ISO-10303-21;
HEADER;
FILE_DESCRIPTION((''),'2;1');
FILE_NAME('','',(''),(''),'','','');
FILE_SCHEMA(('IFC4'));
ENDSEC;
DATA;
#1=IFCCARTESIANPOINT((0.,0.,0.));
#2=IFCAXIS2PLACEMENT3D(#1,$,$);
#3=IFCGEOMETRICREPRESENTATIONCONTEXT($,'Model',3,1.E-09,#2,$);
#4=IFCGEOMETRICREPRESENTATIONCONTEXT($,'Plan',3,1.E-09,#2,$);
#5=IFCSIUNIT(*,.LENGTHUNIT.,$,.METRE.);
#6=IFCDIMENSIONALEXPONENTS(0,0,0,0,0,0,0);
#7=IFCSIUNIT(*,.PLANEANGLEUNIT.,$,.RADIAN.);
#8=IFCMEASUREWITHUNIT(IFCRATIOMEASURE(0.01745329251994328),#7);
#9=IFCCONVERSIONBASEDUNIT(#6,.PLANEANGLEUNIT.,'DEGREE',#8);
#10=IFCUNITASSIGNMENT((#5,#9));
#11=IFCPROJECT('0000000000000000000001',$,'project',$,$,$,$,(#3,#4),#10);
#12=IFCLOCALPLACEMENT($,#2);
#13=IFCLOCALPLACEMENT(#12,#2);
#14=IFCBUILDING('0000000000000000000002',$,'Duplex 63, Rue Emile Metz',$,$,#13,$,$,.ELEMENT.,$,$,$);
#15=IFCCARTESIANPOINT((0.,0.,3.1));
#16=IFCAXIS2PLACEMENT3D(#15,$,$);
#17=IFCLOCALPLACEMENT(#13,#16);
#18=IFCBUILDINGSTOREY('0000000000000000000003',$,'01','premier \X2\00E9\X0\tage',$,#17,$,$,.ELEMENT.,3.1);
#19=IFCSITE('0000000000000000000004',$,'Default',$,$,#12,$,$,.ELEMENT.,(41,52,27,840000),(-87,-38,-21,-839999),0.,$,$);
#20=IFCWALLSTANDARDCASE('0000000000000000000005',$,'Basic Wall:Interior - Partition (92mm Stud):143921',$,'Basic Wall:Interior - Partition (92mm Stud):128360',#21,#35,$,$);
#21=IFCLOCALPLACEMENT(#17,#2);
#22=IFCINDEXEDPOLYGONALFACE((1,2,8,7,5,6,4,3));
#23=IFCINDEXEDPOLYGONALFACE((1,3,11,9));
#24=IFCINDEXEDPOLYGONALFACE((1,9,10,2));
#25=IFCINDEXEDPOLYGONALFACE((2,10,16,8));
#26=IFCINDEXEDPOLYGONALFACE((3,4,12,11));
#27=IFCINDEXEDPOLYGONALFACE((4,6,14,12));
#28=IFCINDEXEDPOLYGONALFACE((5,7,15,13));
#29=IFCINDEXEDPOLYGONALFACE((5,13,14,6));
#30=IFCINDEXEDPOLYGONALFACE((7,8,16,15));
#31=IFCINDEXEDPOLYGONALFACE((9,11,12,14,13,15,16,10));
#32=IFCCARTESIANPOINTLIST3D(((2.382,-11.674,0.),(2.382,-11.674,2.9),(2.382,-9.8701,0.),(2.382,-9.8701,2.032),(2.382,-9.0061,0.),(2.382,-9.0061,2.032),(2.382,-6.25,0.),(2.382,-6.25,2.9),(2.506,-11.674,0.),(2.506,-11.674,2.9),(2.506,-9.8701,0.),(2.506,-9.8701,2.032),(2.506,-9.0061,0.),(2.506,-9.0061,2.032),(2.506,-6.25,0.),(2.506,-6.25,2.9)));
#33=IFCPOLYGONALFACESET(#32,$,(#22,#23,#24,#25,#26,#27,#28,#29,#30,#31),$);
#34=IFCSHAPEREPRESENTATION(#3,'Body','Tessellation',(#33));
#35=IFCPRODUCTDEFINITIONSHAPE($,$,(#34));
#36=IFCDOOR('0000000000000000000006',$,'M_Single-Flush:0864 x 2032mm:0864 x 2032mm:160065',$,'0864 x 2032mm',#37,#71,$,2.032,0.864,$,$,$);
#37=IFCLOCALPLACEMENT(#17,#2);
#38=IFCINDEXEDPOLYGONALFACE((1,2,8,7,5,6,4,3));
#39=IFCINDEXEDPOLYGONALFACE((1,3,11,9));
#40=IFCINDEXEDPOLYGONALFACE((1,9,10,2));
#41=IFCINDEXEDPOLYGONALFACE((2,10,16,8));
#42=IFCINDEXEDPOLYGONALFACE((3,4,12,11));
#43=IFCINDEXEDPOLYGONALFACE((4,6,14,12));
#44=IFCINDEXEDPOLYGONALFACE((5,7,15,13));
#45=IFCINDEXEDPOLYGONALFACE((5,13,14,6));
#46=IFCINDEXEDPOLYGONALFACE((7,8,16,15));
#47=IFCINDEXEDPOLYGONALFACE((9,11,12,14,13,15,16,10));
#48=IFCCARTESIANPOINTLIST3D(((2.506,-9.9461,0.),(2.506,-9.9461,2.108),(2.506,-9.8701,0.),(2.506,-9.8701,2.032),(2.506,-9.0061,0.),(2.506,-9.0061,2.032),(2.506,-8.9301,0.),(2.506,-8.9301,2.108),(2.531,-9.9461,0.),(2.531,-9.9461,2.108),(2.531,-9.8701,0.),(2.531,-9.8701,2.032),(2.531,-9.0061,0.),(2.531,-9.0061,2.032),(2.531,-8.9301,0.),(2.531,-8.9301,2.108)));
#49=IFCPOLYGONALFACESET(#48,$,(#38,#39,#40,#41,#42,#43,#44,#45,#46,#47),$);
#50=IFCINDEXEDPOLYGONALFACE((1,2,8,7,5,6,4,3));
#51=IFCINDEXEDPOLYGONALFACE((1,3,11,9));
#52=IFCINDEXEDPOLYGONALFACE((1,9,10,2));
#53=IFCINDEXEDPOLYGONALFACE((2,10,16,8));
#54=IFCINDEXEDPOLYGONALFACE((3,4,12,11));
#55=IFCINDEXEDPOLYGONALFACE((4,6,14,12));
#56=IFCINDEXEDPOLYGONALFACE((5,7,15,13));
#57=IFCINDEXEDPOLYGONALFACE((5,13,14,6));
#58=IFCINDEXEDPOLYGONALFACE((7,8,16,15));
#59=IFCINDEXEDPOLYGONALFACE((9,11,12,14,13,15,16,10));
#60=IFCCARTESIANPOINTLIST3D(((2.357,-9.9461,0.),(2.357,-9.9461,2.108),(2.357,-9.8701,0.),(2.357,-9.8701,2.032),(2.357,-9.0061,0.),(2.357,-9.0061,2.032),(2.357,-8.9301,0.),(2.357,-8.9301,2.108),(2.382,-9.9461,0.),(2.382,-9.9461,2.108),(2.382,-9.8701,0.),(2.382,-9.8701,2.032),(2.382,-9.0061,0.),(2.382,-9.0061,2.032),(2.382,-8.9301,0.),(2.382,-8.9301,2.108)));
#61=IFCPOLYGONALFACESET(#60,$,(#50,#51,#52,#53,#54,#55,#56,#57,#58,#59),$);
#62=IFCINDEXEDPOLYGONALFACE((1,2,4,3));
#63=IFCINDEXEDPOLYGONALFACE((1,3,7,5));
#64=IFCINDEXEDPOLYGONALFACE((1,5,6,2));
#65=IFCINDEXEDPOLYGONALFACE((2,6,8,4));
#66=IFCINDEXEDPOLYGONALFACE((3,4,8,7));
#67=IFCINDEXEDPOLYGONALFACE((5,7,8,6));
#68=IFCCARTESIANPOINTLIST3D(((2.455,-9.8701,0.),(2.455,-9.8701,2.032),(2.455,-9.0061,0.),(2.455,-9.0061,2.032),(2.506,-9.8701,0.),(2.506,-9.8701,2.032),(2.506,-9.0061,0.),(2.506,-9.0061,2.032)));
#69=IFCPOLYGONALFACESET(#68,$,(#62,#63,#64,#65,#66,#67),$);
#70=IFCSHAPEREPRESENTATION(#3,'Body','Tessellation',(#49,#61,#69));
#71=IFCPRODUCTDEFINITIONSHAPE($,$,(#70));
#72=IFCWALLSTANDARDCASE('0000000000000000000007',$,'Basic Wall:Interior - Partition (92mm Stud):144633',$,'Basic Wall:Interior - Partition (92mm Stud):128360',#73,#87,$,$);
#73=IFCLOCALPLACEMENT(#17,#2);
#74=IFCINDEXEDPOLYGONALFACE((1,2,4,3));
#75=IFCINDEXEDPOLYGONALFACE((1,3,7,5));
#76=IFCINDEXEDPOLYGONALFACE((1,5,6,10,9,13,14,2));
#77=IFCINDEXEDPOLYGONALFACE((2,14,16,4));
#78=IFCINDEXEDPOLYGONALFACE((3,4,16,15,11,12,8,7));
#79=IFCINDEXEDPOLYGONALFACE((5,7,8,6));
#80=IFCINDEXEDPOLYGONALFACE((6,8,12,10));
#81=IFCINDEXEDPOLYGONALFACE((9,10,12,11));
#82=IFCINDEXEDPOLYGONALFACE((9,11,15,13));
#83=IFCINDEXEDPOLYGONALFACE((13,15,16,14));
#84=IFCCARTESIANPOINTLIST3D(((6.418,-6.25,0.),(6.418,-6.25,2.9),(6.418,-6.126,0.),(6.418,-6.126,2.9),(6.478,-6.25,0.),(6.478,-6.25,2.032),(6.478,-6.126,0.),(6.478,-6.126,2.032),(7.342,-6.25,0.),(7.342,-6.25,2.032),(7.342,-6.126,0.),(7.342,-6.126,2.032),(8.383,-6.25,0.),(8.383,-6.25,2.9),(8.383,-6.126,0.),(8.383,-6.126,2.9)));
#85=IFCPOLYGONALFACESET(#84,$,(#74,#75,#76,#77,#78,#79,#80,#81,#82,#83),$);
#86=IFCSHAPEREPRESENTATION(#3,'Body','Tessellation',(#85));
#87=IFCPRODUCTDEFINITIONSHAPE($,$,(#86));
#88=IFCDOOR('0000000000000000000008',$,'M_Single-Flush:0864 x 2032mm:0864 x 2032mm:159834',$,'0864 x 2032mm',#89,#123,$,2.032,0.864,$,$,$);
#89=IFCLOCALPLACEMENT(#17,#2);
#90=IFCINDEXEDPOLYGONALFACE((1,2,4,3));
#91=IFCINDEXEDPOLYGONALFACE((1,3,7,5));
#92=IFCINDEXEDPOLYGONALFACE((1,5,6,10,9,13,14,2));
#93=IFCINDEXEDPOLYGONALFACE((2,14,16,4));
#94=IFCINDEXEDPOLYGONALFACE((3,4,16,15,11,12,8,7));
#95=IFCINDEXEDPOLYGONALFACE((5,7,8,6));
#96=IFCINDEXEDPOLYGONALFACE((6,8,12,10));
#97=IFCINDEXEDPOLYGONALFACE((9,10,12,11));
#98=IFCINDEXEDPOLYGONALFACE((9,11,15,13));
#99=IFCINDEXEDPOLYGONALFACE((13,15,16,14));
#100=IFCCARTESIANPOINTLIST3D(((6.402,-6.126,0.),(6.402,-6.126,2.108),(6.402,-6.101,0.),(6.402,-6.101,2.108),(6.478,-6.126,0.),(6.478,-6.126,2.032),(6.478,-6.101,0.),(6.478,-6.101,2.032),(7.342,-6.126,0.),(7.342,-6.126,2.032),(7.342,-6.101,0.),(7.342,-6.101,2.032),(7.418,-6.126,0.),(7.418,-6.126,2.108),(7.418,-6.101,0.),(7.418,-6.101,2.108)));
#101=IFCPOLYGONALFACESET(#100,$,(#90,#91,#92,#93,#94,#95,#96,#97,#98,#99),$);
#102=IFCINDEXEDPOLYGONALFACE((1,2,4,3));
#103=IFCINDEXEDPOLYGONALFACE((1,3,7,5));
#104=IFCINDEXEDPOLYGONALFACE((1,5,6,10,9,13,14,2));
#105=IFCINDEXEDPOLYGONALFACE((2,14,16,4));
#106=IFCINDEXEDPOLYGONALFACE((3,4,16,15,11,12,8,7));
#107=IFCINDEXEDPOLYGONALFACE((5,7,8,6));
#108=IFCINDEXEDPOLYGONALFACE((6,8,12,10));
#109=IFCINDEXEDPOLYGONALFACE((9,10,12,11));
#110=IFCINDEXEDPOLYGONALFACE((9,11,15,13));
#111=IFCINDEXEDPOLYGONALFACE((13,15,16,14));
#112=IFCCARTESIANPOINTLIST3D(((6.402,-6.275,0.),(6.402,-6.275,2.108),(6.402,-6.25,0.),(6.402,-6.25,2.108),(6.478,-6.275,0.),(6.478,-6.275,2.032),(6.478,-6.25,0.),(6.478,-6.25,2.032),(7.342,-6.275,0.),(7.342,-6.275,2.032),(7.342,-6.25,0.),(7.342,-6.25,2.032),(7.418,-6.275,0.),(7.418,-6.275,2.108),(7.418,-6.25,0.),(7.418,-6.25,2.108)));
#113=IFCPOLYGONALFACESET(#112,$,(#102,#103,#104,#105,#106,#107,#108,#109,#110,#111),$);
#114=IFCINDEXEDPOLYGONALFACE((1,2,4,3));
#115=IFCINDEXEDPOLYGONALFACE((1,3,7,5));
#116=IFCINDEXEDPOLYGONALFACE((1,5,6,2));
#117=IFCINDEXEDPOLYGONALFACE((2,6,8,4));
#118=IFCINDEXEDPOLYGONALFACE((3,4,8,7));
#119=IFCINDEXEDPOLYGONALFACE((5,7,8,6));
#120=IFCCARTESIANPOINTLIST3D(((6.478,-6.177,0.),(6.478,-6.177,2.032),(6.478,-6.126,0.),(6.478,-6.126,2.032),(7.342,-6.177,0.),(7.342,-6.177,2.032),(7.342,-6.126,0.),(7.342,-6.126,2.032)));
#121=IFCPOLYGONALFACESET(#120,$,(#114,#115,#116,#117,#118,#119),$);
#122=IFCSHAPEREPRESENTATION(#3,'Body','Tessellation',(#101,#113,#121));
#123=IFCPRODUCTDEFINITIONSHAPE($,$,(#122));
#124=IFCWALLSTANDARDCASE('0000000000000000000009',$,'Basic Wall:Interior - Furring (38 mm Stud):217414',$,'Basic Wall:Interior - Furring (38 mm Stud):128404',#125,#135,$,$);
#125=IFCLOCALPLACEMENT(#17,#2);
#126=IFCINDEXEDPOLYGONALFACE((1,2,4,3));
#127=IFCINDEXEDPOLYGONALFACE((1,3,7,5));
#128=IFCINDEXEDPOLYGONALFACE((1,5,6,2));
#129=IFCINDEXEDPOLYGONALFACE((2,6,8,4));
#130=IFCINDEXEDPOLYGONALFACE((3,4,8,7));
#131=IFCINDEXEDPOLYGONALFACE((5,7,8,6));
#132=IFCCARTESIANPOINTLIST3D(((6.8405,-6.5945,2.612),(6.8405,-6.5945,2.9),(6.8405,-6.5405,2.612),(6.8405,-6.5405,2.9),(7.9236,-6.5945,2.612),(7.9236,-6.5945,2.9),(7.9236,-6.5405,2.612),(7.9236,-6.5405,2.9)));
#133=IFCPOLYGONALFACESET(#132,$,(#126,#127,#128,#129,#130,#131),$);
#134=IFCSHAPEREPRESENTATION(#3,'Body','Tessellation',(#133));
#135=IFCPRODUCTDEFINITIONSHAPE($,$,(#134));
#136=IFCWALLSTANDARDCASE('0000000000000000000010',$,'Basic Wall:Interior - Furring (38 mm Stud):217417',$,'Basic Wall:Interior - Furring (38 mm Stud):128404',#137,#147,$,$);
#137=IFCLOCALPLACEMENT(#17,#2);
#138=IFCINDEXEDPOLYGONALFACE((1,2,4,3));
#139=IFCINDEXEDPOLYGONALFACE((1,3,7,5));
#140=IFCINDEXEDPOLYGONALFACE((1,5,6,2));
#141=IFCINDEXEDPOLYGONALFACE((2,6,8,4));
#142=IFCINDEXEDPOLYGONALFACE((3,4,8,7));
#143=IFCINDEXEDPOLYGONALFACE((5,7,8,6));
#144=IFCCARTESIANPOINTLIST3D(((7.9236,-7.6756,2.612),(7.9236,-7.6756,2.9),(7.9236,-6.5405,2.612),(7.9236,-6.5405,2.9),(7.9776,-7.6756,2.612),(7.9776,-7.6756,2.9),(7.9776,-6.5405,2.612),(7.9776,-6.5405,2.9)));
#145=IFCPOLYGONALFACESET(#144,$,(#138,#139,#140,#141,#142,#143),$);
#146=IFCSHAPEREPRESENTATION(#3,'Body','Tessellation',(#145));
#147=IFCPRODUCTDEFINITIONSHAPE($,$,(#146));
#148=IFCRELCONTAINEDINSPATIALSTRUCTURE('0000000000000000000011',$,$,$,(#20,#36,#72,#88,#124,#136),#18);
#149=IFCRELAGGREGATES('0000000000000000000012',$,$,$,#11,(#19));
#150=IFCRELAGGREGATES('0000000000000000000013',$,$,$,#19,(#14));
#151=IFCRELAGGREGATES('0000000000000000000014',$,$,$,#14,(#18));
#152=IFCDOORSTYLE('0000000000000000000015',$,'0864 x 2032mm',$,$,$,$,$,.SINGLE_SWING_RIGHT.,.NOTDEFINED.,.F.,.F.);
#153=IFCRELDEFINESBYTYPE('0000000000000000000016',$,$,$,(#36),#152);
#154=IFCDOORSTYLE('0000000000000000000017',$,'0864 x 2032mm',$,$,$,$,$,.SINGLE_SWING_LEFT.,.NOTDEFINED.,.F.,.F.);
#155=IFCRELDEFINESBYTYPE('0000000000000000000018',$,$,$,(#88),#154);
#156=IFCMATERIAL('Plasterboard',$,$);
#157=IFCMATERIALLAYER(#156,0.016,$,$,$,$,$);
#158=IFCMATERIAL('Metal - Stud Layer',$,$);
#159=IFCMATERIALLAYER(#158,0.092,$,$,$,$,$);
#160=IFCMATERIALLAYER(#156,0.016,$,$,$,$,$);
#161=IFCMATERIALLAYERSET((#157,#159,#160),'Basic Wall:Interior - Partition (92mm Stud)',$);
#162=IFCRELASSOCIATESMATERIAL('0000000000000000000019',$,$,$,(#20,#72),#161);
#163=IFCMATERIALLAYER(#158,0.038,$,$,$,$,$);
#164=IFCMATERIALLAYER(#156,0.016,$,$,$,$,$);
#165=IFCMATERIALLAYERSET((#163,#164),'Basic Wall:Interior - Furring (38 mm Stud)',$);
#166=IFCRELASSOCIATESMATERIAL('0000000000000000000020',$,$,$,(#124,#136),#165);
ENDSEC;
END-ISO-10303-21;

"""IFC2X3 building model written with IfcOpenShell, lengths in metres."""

from ifc_helpers import new_model, entity, si_unit, converted_unit, frame, frame_2d, origin, origin_2d_with_axis, place, context, project, spatial, polyline, rectangle, outline, extrude, source, transform, mapped, material, layer, layer_set, layer_usage, type_object, type_shapes, element, fill, save


model = new_model("IFC2X3")

# Units and contexts
model_context = context("Model", 3, precision=1e-09, world=origin())
plan_context = context("Plan", 3, precision=1e-09, world=origin())
ifc_project = project(units=[si_unit("LENGTHUNIT", "METRE"), converted_unit("PLANEANGLEUNIT", "DEGREE", entity("IfcRatioMeasure", 0.01745329251994328), si_unit("PLANEANGLEUNIT", "RADIAN"), dimensions=[0, 0, 0, 0, 0, 0, 0])], contexts=[model_context, plan_context])

# Site, building, storey
site_placement = place(None, origin())
site = spatial("IfcSite", under=ifc_project, at=site_placement, Name="Default", CompositionType="ELEMENT", RefLatitude=(41, 52, 27, 840000), RefLongitude=(-87, -38, -21, -839999), RefElevation=0.0)
building_placement = place(site_placement, origin())
building = spatial("IfcBuilding", under=site, at=building_placement, Name="Duplex 63, Rue Emile Metz", CompositionType="ELEMENT")
storey_placement = place(building_placement, frame((0.0, 0.0, 3.1)))
storey = spatial("IfcBuildingStorey", under=building, at=storey_placement, Name="01", Description="premier étage", CompositionType="ELEMENT", Elevation=3.1)

# Wall, opening, door
ifc_material_1 = material(Name="Plasterboard")
ifc_layer_1 = layer(ifc_material_1, 0.016)
ifc_material_2 = material(Name="Metal - Stud Layer")
ifc_layer_2 = layer(ifc_material_2, 0.092)
ifc_layer_3 = layer(ifc_material_1, 0.016)
ifc_layer_set_1 = layer_set([ifc_layer_1, ifc_layer_2, ifc_layer_3], Name="Basic Wall:Interior - Partition (92mm Stud)")
ifc_layer_usage_1 = layer_usage(ifc_layer_set_1, "AXIS2", "NEGATIVE", 0.062)
wall_1_placement = place(storey_placement, frame((2.444, -6.25, 0.0), z_axis=(0.0, 0.0, 1.0), x_axis=(0.0, -1.0, 0.0)))
wall_1 = element("IfcWallStandardCase", 1, at=wall_1_placement, inside=storey, material=ifc_layer_usage_1, Name="Basic Wall:Interior - Partition (92mm Stud):143921", ObjectType="Basic Wall:Interior - Partition (92mm Stud):128360", context=model_context, shape_type="SweptSolid", body=[
    extrude(rectangle(XDim=5.424, YDim=0.124, at=frame_2d((2.712, 0.0), x_axis=(-1.0, 0.0))), origin(), (0.0, 0.0, 1.0), 2.9),
])
opening_1_placement = place(wall_1_placement, frame((2.7561, -0.062, 0.0)))
opening_1 = element("IfcOpeningElement", 2, at=opening_1_placement, cuts=wall_1, ObjectType="Opening", context=model_context, shape_type="SweptSolid", body=[
    extrude(rectangle(XDim=0.864, YDim=2.032, at=frame_2d((1.016, 0.432), x_axis=(0.0, 1.0))), frame((0.0, 0.0, 0.0), z_axis=(0.0, 1.0, 0.0), x_axis=(0.0, 0.0, 1.0)), (0.0, 0.0, 1.0), 0.124),
])
door_style_1 = type_object("IfcDoorStyle", Name="0864 x 2032mm", ConstructionType="NOTDEFINED", OperationType="SINGLE_SWING_RIGHT", ParameterTakesPrecedence=False, Sizeable=False)
shared_shape_1 = source(origin(), model_context, "Body", "SweptSolid", [
    extrude(outline(polyline([(-0.508, -1.073), (0.508, -1.073), (0.508, 1.035), (0.432, 1.035), (0.432, -0.997), (-0.432, -0.997), (-0.432, 1.035), (-0.508, 1.035), (-0.508, -1.073)])), frame((0.432, 0.124, 1.035), z_axis=(0.0, 1.0, 0.0), x_axis=(1.0, 0.0, 0.0)), (0.0, 0.0, 1.0), 0.025),
    extrude(outline(polyline([(-1.073, -0.508), (1.035, -0.508), (1.035, -0.432), (-0.997, -0.432), (-0.997, 0.432), (1.035, 0.432), (1.035, 0.508), (-1.073, 0.508), (-1.073, -0.508)])), frame((0.432, -0.025, 1.035), z_axis=(0.0, 1.0, 0.0), x_axis=(0.0, 0.0, -1.0)), (0.0, 0.0, 1.0), 0.025),
    extrude(rectangle(XDim=0.051, YDim=0.864, at=origin_2d_with_axis()), frame((0.432, 0.0985, 0.0), z_axis=(0.0, 0.0, 1.0), x_axis=(0.0, 1.0, 0.0)), (0.0, 0.0, 1.0), 2.032),
])
type_shapes(door_style_1, [shared_shape_1])
door_1_placement = place(opening_1_placement, origin())
door_1 = element("IfcDoor", 3, at=door_1_placement, inside=storey, type_object=door_style_1, Name="M_Single-Flush:0864 x 2032mm:0864 x 2032mm:160065", ObjectType="0864 x 2032mm", OverallHeight=2.032, OverallWidth=0.864, context=model_context, shape_type="MappedRepresentation", body=[
    mapped(shared_shape_1, transform((0.0, 0.0, 0.0), scale=1.0)),
])
fill(opening_1, door_1)

# Wall, opening, door
wall_2_placement = place(storey_placement, frame((6.418, -6.188, 0.0)))
wall_2 = element("IfcWallStandardCase", 4, at=wall_2_placement, inside=storey, material=ifc_layer_usage_1, Name="Basic Wall:Interior - Partition (92mm Stud):144633", ObjectType="Basic Wall:Interior - Partition (92mm Stud):128360", context=model_context, shape_type="SweptSolid", body=[
    extrude(rectangle(XDim=1.965, YDim=0.124, at=frame_2d((0.9825, 0.0), x_axis=(-1.0, 0.0))), origin(), (0.0, 0.0, 1.0), 2.9),
])
opening_2_placement = place(wall_2_placement, frame((0.06, -0.062, 0.0)))
opening_2 = element("IfcOpeningElement", 5, at=opening_2_placement, cuts=wall_2, ObjectType="Opening", context=model_context, shape_type="SweptSolid", body=[
    extrude(rectangle(XDim=0.864, YDim=2.032, at=frame_2d((1.016, 0.432), x_axis=(0.0, -1.0))), frame((0.0, 0.0, 0.0), z_axis=(0.0, 1.0, 0.0), x_axis=(0.0, 0.0, 1.0)), (0.0, 0.0, 1.0), 0.124),
])
door_style_2 = type_object("IfcDoorStyle", Name="0864 x 2032mm", ConstructionType="NOTDEFINED", OperationType="SINGLE_SWING_LEFT", ParameterTakesPrecedence=False, Sizeable=False)
shared_shape_2 = source(origin(), model_context, "Body", "SweptSolid", [
    extrude(outline(polyline([(-0.508, -1.073), (0.508, -1.073), (0.508, 1.035), (0.432, 1.035), (0.432, -0.997), (-0.432, -0.997), (-0.432, 1.035), (-0.508, 1.035), (-0.508, -1.073)])), frame((0.432, 0.149, 1.035), z_axis=(0.0, -1.0, 0.0), x_axis=(-1.0, 0.0, 0.0)), (0.0, 0.0, 1.0), 0.025),
    extrude(outline(polyline([(-1.073, -0.508), (1.035, -0.508), (1.035, -0.432), (-0.997, -0.432), (-0.997, 0.432), (1.035, 0.432), (1.035, 0.508), (-1.073, 0.508), (-1.073, -0.508)])), frame((0.432, 0.0, 1.035), z_axis=(0.0, -1.0, 0.0), x_axis=(0.0, 0.0, -1.0)), (0.0, 0.0, 1.0), 0.025),
    extrude(rectangle(XDim=0.864, YDim=0.051, at=origin_2d_with_axis()), frame((0.432, 0.0985, 0.0)), (0.0, 0.0, 1.0), 2.032),
])
type_shapes(door_style_2, [shared_shape_2])
door_2_placement = place(opening_2_placement, origin())
door_2 = element("IfcDoor", 6, at=door_2_placement, inside=storey, type_object=door_style_2, Name="M_Single-Flush:0864 x 2032mm:0864 x 2032mm:159834", ObjectType="0864 x 2032mm", OverallHeight=2.032, OverallWidth=0.864, context=model_context, shape_type="MappedRepresentation", body=[
    mapped(shared_shape_2, transform((0.0, 0.0, 0.0), scale=1.0)),
])
fill(opening_2, door_2)

# Walls
ifc_layer_4 = layer(ifc_material_2, 0.038)
ifc_layer_5 = layer(ifc_material_1, 0.016)
ifc_layer_set_2 = layer_set([ifc_layer_4, ifc_layer_5], Name="Basic Wall:Interior - Furring (38 mm Stud)")
ifc_layer_usage_2 = layer_usage(ifc_layer_set_2, "AXIS2", "NEGATIVE", 0.027)
wall_3_placement = place(storey_placement, frame((6.8405, -6.5675, 2.612)))
element("IfcWallStandardCase", 7, at=wall_3_placement, inside=storey, material=ifc_layer_usage_2, Name="Basic Wall:Interior - Furring (38 mm Stud):217414", ObjectType="Basic Wall:Interior - Furring (38 mm Stud):128404", context=model_context, shape_type="SweptSolid", body=[
    extrude(rectangle(XDim=1.0831, YDim=0.054, at=frame_2d((0.5416, 0.0), x_axis=(-1.0, 0.0))), origin(), (0.0, 0.0, 1.0), 0.288),
])
wall_4_placement = place(storey_placement, frame((7.9506, -6.5405, 2.612), z_axis=(0.0, 0.0, 1.0), x_axis=(0.0, -1.0, 0.0)))
element("IfcWallStandardCase", 8, at=wall_4_placement, inside=storey, material=ifc_layer_usage_2, Name="Basic Wall:Interior - Furring (38 mm Stud):217417", ObjectType="Basic Wall:Interior - Furring (38 mm Stud):128404", context=model_context, shape_type="SweptSolid", body=[
    extrude(rectangle(XDim=1.1351, YDim=0.054, at=frame_2d((0.5675, 0.0), x_axis=(-1.0, 0.0))), origin(), (0.0, 0.0, 1.0), 0.288),
])

save(model, "model.ifc")
